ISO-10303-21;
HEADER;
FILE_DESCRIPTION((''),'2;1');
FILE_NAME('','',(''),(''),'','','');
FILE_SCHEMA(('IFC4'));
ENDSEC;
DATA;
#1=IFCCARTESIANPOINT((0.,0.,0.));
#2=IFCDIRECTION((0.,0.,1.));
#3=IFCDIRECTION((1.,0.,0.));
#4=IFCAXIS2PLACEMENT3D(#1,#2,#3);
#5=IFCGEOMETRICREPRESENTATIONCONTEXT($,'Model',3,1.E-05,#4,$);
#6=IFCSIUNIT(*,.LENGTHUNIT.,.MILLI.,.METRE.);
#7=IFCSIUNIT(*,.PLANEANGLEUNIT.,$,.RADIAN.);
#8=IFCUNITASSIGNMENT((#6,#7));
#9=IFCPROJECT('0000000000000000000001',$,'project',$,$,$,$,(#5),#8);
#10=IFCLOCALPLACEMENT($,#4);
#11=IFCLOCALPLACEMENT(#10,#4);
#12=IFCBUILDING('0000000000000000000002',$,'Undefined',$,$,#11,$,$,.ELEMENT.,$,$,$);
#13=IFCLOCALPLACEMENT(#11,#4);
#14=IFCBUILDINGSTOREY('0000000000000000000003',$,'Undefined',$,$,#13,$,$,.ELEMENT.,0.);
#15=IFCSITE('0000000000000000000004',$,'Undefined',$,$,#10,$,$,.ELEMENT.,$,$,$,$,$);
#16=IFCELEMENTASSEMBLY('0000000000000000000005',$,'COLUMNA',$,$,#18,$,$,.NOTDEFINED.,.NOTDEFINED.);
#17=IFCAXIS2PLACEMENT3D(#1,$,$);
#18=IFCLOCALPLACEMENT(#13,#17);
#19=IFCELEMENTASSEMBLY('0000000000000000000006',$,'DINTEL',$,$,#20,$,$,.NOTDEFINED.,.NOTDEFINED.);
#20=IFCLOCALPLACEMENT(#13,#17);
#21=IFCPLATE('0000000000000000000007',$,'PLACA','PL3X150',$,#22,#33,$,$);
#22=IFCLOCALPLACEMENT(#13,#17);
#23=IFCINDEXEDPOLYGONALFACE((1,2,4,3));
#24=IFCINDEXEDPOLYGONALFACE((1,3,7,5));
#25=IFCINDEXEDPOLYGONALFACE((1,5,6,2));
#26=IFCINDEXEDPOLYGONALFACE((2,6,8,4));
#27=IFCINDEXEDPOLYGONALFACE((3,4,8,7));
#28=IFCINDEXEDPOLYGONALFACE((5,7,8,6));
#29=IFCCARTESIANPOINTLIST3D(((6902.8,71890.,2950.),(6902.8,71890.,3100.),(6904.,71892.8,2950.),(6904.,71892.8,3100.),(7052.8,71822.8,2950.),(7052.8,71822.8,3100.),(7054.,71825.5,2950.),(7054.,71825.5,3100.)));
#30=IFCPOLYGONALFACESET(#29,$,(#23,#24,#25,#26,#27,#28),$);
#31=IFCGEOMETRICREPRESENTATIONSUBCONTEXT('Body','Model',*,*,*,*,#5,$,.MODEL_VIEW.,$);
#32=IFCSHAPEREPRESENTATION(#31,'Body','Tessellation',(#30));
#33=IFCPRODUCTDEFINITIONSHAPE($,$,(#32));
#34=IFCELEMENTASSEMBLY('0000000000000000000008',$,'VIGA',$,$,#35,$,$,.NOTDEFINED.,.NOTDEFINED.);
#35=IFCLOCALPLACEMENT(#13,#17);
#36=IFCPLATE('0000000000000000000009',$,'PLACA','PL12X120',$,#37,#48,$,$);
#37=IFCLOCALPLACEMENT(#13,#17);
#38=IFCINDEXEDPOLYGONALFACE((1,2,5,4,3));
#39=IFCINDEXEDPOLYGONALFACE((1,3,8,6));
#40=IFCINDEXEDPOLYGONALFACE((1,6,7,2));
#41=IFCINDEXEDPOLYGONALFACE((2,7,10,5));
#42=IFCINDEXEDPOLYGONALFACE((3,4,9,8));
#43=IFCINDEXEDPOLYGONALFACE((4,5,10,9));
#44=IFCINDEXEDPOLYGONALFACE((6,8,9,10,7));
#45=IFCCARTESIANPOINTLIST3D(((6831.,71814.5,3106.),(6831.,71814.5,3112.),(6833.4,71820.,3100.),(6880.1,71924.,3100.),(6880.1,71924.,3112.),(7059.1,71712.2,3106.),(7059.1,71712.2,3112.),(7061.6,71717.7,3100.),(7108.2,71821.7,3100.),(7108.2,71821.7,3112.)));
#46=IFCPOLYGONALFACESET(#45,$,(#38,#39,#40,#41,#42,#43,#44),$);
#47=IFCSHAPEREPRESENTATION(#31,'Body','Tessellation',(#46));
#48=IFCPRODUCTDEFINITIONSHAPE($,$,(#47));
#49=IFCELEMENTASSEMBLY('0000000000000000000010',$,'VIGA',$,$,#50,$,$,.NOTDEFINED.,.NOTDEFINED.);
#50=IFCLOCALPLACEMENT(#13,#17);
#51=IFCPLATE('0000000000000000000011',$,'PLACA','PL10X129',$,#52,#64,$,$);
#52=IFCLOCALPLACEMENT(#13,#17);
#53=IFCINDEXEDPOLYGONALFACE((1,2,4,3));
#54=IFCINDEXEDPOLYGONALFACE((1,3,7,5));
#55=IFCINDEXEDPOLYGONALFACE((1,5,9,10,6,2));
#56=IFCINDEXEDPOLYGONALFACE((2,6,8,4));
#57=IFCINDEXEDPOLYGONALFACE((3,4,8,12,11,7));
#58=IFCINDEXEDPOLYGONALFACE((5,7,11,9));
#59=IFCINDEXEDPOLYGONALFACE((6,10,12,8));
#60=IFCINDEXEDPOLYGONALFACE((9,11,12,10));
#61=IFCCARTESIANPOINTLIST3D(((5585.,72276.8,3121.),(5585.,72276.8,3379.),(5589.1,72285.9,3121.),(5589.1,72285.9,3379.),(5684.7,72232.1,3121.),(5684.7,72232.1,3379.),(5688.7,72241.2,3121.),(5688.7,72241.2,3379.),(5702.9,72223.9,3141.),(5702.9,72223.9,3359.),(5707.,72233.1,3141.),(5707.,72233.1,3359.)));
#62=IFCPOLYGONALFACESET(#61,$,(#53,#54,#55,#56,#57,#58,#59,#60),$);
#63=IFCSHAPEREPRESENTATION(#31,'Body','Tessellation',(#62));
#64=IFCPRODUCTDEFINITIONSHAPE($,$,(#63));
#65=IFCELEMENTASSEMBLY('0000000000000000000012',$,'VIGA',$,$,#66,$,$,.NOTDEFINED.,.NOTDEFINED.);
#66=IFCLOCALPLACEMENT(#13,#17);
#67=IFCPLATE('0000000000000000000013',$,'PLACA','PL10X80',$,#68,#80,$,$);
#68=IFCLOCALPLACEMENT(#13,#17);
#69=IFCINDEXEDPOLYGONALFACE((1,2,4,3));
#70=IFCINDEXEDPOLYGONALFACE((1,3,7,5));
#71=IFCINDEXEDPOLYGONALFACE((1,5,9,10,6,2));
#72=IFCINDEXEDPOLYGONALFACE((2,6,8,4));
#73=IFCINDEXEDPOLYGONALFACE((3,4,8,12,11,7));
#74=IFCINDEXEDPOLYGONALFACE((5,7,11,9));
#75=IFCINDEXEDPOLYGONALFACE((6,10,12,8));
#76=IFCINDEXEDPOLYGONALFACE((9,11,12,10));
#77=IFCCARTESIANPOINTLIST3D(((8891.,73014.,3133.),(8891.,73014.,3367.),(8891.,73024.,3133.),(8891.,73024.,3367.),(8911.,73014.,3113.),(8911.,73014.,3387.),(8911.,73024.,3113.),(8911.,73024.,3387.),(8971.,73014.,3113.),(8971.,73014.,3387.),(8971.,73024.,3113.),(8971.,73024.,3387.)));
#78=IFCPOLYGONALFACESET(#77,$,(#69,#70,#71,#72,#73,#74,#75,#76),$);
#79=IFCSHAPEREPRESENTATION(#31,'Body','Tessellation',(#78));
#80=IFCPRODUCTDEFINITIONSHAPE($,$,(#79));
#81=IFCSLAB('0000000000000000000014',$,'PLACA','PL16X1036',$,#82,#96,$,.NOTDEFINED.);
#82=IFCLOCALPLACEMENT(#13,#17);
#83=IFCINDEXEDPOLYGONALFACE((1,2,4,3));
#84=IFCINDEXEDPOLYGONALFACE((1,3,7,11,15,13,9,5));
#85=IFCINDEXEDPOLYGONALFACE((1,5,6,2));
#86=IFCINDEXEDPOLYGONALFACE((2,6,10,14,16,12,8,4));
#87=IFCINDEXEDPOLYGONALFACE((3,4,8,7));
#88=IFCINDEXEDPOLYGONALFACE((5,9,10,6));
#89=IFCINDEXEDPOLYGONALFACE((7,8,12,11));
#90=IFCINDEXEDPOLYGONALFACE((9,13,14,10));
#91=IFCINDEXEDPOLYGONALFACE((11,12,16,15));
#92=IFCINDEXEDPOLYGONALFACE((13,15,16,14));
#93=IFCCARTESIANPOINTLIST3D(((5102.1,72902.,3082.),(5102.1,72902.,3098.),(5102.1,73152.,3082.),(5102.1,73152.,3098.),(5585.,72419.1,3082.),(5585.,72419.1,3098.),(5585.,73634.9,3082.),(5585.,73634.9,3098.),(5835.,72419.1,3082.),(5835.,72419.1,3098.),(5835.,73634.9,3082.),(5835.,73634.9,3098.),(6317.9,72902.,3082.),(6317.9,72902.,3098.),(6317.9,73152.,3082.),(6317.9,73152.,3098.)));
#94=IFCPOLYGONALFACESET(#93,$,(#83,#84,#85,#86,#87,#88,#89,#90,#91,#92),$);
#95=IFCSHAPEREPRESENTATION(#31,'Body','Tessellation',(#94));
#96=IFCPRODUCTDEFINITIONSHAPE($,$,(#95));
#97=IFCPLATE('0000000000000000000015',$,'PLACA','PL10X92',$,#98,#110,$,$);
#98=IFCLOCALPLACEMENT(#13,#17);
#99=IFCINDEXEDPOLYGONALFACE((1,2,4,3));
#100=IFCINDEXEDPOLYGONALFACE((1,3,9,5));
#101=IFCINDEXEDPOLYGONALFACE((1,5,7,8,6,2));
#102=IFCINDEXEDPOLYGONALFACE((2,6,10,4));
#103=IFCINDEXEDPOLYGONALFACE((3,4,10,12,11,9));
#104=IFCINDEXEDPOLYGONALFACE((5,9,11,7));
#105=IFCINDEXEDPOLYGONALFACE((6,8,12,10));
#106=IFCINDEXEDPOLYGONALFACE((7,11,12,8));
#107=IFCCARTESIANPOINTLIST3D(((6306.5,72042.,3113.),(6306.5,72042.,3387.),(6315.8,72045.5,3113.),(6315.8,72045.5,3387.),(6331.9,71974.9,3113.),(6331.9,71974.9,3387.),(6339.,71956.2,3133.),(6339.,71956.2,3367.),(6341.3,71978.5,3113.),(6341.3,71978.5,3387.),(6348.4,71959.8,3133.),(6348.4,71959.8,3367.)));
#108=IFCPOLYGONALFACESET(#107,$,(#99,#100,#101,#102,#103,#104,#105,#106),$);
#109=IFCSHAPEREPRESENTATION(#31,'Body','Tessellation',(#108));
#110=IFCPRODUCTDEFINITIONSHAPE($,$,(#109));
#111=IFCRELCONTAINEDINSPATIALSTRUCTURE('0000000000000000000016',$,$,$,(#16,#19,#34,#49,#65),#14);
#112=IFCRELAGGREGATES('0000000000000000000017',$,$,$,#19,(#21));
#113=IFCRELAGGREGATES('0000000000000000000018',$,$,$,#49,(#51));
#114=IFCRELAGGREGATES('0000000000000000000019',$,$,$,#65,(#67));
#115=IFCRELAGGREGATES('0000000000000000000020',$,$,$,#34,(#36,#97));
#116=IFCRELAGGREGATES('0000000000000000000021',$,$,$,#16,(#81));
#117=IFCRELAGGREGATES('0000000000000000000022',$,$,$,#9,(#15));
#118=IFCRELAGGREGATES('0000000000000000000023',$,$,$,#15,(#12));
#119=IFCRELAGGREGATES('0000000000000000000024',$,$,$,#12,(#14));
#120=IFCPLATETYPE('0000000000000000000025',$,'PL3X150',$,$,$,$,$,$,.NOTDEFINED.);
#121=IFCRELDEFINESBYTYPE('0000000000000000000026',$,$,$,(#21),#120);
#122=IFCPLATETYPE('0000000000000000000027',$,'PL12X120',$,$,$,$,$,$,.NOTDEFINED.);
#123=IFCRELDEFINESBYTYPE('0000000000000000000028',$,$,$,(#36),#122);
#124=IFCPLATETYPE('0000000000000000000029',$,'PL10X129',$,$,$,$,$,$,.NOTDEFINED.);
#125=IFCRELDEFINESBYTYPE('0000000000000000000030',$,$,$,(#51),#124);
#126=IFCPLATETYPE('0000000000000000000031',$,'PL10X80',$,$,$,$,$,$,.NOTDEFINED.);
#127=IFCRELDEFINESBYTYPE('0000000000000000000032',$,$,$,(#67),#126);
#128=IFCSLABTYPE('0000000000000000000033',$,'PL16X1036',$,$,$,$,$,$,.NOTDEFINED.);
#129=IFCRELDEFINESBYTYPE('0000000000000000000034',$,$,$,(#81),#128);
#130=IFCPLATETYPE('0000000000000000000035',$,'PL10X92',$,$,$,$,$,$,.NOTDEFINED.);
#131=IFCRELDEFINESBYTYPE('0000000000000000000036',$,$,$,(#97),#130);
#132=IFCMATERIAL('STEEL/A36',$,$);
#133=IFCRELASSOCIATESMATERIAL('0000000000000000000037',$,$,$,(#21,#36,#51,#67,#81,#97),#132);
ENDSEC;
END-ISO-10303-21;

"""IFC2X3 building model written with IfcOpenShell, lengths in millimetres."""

from ifc_helpers import new_model, si_unit, frame, origin_with_axes, place, context, subcontext, project, spatial, polyline, outline, extrude, boolean, material, type_object, element, aggregate, save


model = new_model("IFC2X3")

# Units and contexts
model_context = context("Model", 3, precision=1e-05, world=origin_with_axes())
body_context = subcontext(model_context, "Body", "Model", "MODEL_VIEW")
ifc_project = project(units=[si_unit("LENGTHUNIT", "METRE", prefix="MILLI"), si_unit("PLANEANGLEUNIT", "RADIAN")], contexts=[model_context])

# Site, building, storey
site_placement = place(None, origin_with_axes())
site = spatial("IfcSite", under=ifc_project, at=site_placement, Name="Undefined", CompositionType="ELEMENT")
building_placement = place(site_placement, origin_with_axes())
building = spatial("IfcBuilding", under=site, at=building_placement, Name="Undefined", CompositionType="ELEMENT")
storey_placement = place(building_placement, origin_with_axes())
storey = spatial("IfcBuildingStorey", under=building, at=storey_placement, Name="Undefined", CompositionType="ELEMENT", Elevation=0.0)

# Element assembly
assembly_1_placement = place(storey_placement, origin_with_axes())
assembly_1 = element("IfcElementAssembly", 1, at=assembly_1_placement, inside=storey, Name="COLUMNA", AssemblyPlace="NOTDEFINED", PredefinedType="NOTDEFINED")
ifc_material_1 = material(Name="STEEL/A36")

# Element assembly
assembly_2_placement = place(storey_placement, origin_with_axes())
assembly_2 = element("IfcElementAssembly", 2, at=assembly_2_placement, inside=storey, Name="DINTEL", AssemblyPlace="NOTDEFINED", PredefinedType="NOTDEFINED")

# Plate
plate_type_1 = type_object("IfcPlateType", Name="PL3X150", PredefinedType="NOTDEFINED")
plate_1_placement = place(assembly_2_placement, frame((7053.4, 71824.1, 2950.0), z_axis=(0.409159, 0.912463, 0.0), x_axis=(-0.912463, 0.409159, 0.0)))
plate_1 = element("IfcPlate", 3, at=plate_1_placement, type_object=plate_type_1, material=ifc_material_1, Name="PLACA", Description="PL3X150", context=body_context, shape_type="SweptSolid", body=[
    extrude(outline(polyline([(0.0, 0.0), (164.4, 0.0), (164.4, 150.0), (0.0, 150.0), (0.0, 0.0)])), frame((0.0, 0.0, -1.5), z_axis=(0.0, 0.0, 1.0), x_axis=(1.0, 0.0, 0.0)), (0.0, 0.0, 1.0), 3.0),
])
aggregate(assembly_2, [plate_1])

# Element assembly, plate
assembly_3_placement = place(storey_placement, origin_with_axes())
assembly_3 = element("IfcElementAssembly", 4, at=assembly_3_placement, inside=storey, Name="VIGA", AssemblyPlace="NOTDEFINED", PredefinedType="NOTDEFINED")
plate_type_2 = type_object("IfcPlateType", Name="PL12X120", PredefinedType="NOTDEFINED")
plate_2_placement = place(assembly_3_placement, frame((7059.1, 71712.2, 3106.0), z_axis=(0.0, 0.0, -1.0), x_axis=(-0.912465, 0.409155, 0.0)))
plate_2 = element("IfcPlate", 5, at=plate_2_placement, type_object=plate_type_2, material=ifc_material_1, Name="PLACA", Description="PL12X120", context=body_context, shape_type="CSG", body=[
    boolean("DIFFERENCE", extrude(outline(polyline([(0.0, 0.0), (250.0, 0.0), (250.0, 120.0), (0.0, 120.0), (0.0, 0.0)])), frame((0.0, 0.0, -6.0), z_axis=(0.0, 0.0, 1.0), x_axis=(1.0, 0.0, 0.0)), (0.0, 0.0, 1.0), 12.0), extrude(outline(polyline([(0.0, 0.0), (6.0, 0.0), (6.0, 6.0), (0.0, 0.0)])), frame((-75.0, 6.0, 6.0), z_axis=(1.0, 0.0, 0.0), x_axis=(0.0, -1.0, 0.0)), (0.0, 0.0, 1.0), 400.0)),
])

# Element assembly, plate
assembly_4_placement = place(storey_placement, origin_with_axes())
assembly_4 = element("IfcElementAssembly", 6, at=assembly_4_placement, inside=storey, Name="VIGA", AssemblyPlace="NOTDEFINED", PredefinedType="NOTDEFINED")
plate_type_3 = type_object("IfcPlateType", Name="PL10X129", PredefinedType="NOTDEFINED")
plate_3_placement = place(assembly_4_placement, frame((5705.0, 72228.5, 3121.0), z_axis=(0.409155, 0.912465, 0.0), x_axis=(-0.912465, 0.409155, 0.0)))
plate_3 = element("IfcPlate", 7, at=plate_3_placement, type_object=plate_type_3, material=ifc_material_1, Name="PLACA", Description="PL10X129", context=body_context, shape_type="SweptSolid", body=[
    extrude(outline(polyline([(0.0, 20.0), (20.0, 0.0), (129.2, 0.0), (129.2, 258.0), (20.0, 258.0), (0.0, 238.0), (0.0, 20.0)])), frame((0.0, 0.0, -5.0), z_axis=(0.0, 0.0, 1.0), x_axis=(1.0, 0.0, 0.0)), (0.0, 0.0, 1.0), 10.0),
])
aggregate(assembly_4, [plate_3])

# Element assembly, plate
assembly_5_placement = place(storey_placement, origin_with_axes())
assembly_5 = element("IfcElementAssembly", 8, at=assembly_5_placement, inside=storey, Name="VIGA", AssemblyPlace="NOTDEFINED", PredefinedType="NOTDEFINED")
plate_type_4 = type_object("IfcPlateType", Name="PL10X80", PredefinedType="NOTDEFINED")
plate_4_placement = place(assembly_5_placement, frame((8891.0, 73019.0, 3113.0), z_axis=(0.0, -1.0, 0.0), x_axis=(1.0, 0.0, 0.0)))
plate_4 = element("IfcPlate", 9, at=plate_4_placement, type_object=plate_type_4, material=ifc_material_1, Name="PLACA", Description="PL10X80", context=body_context, shape_type="SweptSolid", body=[
    extrude(outline(polyline([(0.0, 20.0), (20.0, 0.0), (80.0, 0.0), (80.0, 274.0), (20.0, 274.0), (0.0, 254.0), (0.0, 20.0)])), frame((0.0, 0.0, -5.0), z_axis=(0.0, 0.0, 1.0), x_axis=(1.0, 0.0, 0.0)), (0.0, 0.0, 1.0), 10.0),
])
aggregate(assembly_5, [plate_4])

# Slab
slab_type = type_object("IfcSlabType", Name="PL16X1036", PredefinedType="NOTDEFINED")
slab_placement = place(assembly_1_placement, frame((5835.0, 72419.1, 3090.0), z_axis=(0.0, 0.0, 1.0), x_axis=(0.707107, 0.707107, 0.0)))
slab = element("IfcSlab", 10, at=slab_placement, type_object=slab_type, material=ifc_material_1, Name="PLACA", Description="PL16X1036", PredefinedType="NOTDEFINED", context=body_context, shape_type="SweptSolid", body=[
    extrude(outline(polyline([(0.0, 0.0), (682.9, 0.0), (859.7, 176.8), (859.7, 859.7), (682.9, 1036.5), (0.0, 1036.5), (-176.8, 859.7), (-176.8, 176.8), (0.0, 0.0)])), frame((0.0, 0.0, -8.0), z_axis=(0.0, 0.0, 1.0), x_axis=(1.0, 0.0, 0.0)), (0.0, 0.0, 1.0), 16.0),
])

# Plate
plate_type_5 = type_object("IfcPlateType", Name="PL10X92", PredefinedType="NOTDEFINED")
plate_5_placement = place(assembly_3_placement, frame((6343.7, 71958.0, 3113.0), z_axis=(0.934891, 0.354934, 0.0), x_axis=(-0.354934, 0.934891, 0.0)))
plate_5 = element("IfcPlate", 11, at=plate_5_placement, type_object=plate_type_5, material=ifc_material_1, Name="PLACA", Description="PL10X92", context=body_context, shape_type="SweptSolid", body=[
    extrude(outline(polyline([(0.0, 20.0), (20.0, 0.0), (91.7, 0.0), (91.7, 274.0), (20.0, 274.0), (0.0, 254.0), (0.0, 20.0)])), frame((0.0, 0.0, -5.0), z_axis=(0.0, 0.0, 1.0), x_axis=(1.0, 0.0, 0.0)), (0.0, 0.0, 1.0), 10.0),
])

aggregate(assembly_3, [plate_2, plate_5])

aggregate(assembly_1, [slab])

save(model, "model.ifc")
